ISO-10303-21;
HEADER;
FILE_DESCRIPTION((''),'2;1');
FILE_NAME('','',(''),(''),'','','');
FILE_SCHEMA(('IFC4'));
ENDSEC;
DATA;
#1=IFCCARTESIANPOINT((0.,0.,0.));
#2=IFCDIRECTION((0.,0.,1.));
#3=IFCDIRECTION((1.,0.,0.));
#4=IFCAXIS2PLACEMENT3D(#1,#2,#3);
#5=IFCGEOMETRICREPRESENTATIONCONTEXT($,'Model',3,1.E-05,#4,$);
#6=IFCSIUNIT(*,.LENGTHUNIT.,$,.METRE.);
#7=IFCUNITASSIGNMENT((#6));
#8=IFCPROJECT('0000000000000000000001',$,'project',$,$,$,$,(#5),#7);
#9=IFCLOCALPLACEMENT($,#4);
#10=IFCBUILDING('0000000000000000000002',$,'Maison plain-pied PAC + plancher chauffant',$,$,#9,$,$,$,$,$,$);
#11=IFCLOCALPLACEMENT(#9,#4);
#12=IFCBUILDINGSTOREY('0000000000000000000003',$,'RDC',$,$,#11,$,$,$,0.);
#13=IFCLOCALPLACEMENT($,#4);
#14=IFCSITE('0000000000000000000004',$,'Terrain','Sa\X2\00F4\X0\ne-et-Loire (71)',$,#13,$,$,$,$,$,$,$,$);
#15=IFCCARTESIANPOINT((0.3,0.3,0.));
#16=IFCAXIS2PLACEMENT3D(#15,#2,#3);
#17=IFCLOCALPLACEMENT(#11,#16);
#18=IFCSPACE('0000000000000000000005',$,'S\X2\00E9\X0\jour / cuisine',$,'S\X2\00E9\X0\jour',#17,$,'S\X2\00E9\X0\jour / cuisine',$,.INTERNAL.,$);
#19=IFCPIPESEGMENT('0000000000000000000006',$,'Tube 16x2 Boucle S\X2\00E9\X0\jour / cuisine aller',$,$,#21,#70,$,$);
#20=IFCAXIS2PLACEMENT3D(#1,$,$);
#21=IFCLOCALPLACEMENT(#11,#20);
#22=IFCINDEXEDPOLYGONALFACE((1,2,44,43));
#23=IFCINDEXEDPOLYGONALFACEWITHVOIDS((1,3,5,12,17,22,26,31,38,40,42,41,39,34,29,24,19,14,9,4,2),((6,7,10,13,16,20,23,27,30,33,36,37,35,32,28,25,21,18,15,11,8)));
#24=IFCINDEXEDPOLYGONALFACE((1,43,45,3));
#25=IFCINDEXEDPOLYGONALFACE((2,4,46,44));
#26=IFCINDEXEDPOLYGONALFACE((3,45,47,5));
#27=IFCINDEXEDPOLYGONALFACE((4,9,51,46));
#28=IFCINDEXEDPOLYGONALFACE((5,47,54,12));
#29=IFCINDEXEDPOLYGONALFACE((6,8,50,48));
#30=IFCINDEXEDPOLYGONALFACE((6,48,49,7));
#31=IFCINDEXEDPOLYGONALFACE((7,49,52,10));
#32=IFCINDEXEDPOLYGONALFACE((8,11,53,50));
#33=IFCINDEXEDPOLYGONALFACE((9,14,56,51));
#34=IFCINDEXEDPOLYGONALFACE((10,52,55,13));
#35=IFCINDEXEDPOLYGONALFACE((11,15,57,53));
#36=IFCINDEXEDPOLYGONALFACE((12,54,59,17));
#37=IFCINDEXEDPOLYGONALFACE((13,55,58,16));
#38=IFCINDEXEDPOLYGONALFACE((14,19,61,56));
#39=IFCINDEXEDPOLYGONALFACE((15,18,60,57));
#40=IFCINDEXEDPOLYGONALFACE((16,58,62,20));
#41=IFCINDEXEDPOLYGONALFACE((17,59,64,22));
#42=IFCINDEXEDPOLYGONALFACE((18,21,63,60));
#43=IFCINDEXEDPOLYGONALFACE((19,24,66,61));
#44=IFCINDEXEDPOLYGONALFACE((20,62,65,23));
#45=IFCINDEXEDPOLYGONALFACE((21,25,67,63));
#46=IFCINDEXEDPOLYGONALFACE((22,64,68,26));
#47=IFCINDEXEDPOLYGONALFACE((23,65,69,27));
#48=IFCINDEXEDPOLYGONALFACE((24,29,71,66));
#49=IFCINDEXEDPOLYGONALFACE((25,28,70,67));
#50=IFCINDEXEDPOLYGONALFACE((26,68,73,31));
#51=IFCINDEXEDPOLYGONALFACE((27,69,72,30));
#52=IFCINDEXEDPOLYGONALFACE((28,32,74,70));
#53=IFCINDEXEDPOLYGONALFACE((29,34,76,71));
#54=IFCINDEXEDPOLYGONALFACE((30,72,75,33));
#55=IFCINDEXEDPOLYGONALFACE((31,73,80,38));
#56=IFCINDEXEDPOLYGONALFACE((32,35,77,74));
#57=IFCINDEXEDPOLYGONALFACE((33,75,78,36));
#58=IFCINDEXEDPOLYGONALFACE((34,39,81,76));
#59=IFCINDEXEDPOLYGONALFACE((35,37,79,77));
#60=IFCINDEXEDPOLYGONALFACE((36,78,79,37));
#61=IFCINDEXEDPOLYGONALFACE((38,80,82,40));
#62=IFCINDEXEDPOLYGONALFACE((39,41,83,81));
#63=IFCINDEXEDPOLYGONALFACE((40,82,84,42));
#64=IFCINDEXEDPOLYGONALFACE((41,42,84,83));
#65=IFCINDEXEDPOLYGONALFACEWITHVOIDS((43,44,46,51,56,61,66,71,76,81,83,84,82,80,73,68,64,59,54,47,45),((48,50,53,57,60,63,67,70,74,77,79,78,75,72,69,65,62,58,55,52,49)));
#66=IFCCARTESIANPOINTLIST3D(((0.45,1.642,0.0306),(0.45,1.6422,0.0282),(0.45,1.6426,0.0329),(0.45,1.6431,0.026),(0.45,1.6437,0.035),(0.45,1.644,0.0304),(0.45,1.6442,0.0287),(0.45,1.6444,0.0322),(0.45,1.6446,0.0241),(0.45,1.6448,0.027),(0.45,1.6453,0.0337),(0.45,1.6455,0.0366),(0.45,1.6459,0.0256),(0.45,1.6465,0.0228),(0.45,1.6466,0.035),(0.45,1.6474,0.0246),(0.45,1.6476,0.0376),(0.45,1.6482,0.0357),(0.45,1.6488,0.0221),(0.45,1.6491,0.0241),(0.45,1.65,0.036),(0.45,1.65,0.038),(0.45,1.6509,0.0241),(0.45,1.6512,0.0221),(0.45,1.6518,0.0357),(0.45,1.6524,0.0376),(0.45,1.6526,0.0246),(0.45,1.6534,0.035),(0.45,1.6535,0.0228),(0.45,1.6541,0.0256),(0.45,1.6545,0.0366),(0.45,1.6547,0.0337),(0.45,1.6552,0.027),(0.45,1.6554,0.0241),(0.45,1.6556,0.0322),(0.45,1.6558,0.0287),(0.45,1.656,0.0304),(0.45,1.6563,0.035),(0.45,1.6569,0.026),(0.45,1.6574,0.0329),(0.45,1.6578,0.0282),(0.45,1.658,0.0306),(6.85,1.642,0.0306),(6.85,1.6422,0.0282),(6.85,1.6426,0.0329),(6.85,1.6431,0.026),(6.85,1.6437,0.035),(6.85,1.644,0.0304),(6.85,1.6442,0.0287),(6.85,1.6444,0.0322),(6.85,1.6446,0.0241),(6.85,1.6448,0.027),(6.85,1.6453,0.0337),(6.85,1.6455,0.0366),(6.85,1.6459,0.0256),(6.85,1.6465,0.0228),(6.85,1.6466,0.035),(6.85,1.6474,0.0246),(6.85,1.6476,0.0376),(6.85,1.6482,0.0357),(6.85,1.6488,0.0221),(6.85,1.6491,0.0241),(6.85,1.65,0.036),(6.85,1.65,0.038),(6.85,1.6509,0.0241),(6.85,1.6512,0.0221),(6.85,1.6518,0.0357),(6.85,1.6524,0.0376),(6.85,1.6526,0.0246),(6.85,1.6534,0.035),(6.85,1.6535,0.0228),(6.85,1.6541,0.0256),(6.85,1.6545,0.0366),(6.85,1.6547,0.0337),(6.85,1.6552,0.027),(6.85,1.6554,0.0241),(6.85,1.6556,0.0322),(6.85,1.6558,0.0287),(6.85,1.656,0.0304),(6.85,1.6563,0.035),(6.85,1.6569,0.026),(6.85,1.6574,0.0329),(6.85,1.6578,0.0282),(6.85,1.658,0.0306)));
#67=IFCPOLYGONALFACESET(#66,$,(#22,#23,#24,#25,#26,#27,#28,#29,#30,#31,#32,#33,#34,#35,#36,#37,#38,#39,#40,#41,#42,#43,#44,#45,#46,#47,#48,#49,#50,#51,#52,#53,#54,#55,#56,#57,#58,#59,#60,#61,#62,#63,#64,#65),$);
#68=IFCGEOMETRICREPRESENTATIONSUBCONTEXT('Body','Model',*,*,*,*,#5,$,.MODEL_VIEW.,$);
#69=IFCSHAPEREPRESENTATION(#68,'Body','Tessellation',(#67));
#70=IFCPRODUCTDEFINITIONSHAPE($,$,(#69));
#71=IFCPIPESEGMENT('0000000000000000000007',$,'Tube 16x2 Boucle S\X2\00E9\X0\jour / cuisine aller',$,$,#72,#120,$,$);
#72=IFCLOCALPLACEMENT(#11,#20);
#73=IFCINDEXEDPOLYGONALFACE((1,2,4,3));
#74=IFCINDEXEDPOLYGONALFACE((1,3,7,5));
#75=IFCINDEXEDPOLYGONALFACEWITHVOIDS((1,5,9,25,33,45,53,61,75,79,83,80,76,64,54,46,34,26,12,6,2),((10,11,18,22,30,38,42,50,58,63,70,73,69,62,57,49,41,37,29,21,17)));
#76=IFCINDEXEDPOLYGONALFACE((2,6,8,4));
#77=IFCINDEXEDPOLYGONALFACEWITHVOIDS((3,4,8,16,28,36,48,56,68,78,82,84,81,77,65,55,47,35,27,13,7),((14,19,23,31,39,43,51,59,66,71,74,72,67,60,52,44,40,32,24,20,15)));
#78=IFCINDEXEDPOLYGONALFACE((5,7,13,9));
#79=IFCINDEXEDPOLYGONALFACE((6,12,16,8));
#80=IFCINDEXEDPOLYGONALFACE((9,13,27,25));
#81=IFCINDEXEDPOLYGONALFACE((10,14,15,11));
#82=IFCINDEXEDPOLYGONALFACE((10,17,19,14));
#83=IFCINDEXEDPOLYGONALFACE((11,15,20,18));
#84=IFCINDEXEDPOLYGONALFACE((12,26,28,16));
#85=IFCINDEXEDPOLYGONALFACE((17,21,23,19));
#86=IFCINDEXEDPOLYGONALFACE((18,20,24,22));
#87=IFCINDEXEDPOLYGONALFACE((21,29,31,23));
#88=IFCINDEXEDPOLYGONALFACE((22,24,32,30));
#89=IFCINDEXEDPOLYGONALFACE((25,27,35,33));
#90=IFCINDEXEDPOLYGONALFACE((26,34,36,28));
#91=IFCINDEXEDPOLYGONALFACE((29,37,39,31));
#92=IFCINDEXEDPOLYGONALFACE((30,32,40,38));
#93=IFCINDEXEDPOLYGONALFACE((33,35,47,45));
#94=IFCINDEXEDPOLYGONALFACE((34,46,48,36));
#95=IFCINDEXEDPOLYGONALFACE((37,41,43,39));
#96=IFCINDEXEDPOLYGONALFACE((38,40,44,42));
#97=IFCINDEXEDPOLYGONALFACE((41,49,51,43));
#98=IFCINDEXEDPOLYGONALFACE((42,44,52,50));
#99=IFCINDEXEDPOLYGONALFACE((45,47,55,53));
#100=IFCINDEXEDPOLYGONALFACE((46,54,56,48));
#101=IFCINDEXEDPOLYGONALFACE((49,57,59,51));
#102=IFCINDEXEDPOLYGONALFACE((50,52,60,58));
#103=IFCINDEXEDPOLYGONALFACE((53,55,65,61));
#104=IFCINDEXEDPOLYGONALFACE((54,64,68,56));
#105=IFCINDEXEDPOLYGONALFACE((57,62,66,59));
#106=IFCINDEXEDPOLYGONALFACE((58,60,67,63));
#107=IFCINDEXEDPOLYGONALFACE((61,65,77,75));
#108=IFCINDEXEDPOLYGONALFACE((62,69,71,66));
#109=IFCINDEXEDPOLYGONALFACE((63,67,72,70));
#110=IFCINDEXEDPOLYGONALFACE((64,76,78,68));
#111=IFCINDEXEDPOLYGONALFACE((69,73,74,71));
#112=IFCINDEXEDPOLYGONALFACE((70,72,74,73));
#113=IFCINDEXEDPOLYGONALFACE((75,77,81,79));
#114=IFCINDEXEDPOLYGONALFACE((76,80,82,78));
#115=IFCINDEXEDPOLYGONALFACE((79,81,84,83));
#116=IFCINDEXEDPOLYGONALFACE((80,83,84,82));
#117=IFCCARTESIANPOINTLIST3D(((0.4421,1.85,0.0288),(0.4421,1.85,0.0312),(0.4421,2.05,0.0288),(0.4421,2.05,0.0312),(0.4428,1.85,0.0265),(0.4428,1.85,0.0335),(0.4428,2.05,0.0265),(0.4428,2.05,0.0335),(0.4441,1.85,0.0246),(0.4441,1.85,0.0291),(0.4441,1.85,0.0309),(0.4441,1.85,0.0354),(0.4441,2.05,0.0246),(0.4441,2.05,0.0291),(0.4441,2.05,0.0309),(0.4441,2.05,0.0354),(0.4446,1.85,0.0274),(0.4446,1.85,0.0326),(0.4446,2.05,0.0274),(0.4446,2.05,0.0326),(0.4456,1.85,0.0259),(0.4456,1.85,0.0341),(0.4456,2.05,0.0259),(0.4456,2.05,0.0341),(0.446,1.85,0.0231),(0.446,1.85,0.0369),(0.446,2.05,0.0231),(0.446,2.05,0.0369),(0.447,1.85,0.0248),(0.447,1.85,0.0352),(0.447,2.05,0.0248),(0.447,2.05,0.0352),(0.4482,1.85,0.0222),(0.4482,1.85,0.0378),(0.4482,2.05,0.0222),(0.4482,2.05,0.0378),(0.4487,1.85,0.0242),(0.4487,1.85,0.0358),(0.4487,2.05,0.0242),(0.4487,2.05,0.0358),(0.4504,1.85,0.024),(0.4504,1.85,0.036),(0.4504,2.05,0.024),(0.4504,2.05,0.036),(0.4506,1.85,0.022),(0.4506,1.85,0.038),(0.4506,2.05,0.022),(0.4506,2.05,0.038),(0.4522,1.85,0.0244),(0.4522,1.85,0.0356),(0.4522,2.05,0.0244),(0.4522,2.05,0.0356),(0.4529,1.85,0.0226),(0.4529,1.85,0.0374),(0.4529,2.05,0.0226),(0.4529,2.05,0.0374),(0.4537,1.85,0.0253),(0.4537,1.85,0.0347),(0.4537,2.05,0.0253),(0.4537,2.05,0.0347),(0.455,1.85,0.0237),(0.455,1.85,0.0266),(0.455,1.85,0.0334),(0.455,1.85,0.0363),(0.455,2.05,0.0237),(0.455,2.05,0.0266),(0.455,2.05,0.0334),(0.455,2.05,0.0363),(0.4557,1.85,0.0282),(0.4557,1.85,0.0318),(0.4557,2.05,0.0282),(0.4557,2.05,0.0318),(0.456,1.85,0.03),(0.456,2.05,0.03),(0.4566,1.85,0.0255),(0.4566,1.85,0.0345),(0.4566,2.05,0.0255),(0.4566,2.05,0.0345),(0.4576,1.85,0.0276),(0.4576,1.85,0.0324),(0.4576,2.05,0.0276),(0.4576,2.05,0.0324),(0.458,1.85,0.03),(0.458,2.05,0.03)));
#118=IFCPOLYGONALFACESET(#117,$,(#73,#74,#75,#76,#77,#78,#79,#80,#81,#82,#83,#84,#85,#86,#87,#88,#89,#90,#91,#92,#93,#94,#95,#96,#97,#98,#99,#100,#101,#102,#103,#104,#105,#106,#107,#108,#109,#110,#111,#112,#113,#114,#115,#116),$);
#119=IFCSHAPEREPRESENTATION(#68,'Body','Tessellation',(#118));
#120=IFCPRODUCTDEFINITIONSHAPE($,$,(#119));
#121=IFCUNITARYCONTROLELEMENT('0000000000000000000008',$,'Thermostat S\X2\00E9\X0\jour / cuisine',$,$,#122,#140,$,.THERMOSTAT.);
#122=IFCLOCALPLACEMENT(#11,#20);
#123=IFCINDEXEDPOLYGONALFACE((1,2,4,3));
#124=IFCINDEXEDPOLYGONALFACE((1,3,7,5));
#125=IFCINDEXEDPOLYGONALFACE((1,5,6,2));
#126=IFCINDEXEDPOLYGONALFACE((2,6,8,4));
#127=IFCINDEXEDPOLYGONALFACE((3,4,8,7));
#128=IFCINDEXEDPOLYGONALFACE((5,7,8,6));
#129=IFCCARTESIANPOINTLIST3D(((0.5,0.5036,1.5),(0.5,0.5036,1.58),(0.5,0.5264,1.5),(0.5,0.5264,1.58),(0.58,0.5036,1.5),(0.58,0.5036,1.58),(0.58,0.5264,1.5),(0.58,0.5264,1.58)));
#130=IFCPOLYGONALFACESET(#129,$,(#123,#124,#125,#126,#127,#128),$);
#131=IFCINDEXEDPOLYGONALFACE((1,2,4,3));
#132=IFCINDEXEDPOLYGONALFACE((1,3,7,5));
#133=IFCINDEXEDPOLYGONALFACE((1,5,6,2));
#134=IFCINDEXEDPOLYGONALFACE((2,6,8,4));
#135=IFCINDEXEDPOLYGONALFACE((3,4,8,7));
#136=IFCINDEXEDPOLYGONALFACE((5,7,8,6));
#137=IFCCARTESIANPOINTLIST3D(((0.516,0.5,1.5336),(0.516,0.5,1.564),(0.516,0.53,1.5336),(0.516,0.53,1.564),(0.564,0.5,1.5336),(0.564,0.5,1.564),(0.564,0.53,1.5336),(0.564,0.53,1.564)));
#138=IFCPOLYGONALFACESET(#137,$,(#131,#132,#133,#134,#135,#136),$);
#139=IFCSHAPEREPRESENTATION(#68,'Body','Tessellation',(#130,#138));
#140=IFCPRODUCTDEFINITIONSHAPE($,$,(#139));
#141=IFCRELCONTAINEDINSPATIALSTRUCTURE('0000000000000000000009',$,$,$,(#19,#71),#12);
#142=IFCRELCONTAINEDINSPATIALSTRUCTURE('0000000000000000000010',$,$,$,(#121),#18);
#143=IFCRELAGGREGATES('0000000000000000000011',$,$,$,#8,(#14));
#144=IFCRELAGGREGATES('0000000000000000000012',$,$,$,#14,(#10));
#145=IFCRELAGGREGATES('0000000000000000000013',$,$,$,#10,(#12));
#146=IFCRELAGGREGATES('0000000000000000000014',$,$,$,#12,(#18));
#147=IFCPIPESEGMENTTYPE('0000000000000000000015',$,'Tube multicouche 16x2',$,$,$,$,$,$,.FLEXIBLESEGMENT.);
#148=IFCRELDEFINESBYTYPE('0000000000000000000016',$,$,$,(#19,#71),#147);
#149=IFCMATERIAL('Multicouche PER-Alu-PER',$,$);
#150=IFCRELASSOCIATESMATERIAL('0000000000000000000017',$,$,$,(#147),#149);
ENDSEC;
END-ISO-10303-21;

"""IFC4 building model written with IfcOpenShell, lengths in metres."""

from ifc_helpers import new_model, si_unit, frame, frame_2d, origin_with_axes, place, context, subcontext, project, spatial, rectangle, hollow_circle, extrude, material, type_object, element, save


model = new_model("IFC4")

# Units and contexts
model_context = context("Model", 3, precision=1e-05, world=origin_with_axes())
body_context = subcontext(model_context, "Body", "Model", "MODEL_VIEW")
ifc_project = project(units=[si_unit("LENGTHUNIT", "METRE")], contexts=[model_context])

# Site, building, storey
site_placement = place(None, origin_with_axes())
site = spatial("IfcSite", under=ifc_project, at=site_placement, Name="Terrain", Description="Saône-et-Loire (71)")
building_placement = place(None, origin_with_axes())
building = spatial("IfcBuilding", under=site, at=building_placement, Name="Maison plain-pied PAC + plancher chauffant")
storey_placement = place(building_placement, origin_with_axes())
storey = spatial("IfcBuildingStorey", under=building, at=storey_placement, Name="RDC", Elevation=0.0)

# Pipe segments
ifc_material_1 = material(Name="Multicouche PER-Alu-PER")
pipe_segment_type = type_object("IfcPipeSegmentType", Name="Tube multicouche 16x2", PredefinedType="FLEXIBLESEGMENT", material=ifc_material_1)
pipe_segment_1_placement = place(storey_placement, frame((0.45, 1.65, 0.03), z_axis=(1.0, 0.0, 0.0), x_axis=(0.0, 0.0, 1.0)))
element("IfcPipeSegment", 1, at=pipe_segment_1_placement, inside=storey, type_object=pipe_segment_type, Name="Tube 16x2 Boucle Séjour / cuisine aller", context=body_context, shape_type="SweptSolid", body=[
    extrude(hollow_circle(Radius=0.008, WallThickness=0.002), origin_with_axes(), (0.0, 0.0, 1.0), 6.4),
])
pipe_segment_2_placement = place(storey_placement, frame((0.45, 1.85, 0.03), z_axis=(0.0, 1.0, 0.0), x_axis=(1.0, 0.0, 0.0)))
element("IfcPipeSegment", 2, at=pipe_segment_2_placement, inside=storey, type_object=pipe_segment_type, Name="Tube 16x2 Boucle Séjour / cuisine aller", context=body_context, shape_type="SweptSolid", body=[
    extrude(hollow_circle(Radius=0.008, WallThickness=0.002), origin_with_axes(), (0.0, 0.0, 1.0), 0.2),
])

# Shared definitions
space_placement = place(storey_placement, frame((0.3, 0.3, 0.0), z_axis=(0.0, 0.0, 1.0), x_axis=(1.0, 0.0, 0.0)))
space = spatial("IfcSpace", under=storey, at=space_placement, Name="Séjour / cuisine", ObjectType="Séjour", LongName="Séjour / cuisine", PredefinedType="INTERNAL")

# Unitary control element
unitary_control_element_placement = place(space_placement, frame((0.2, 0.2, 1.5), z_axis=(0.0, 0.0, 1.0), x_axis=(1.0, 0.0, 0.0)))
element("IfcUnitaryControlElement", 3, at=unitary_control_element_placement, inside=space, Name="Thermostat Séjour / cuisine", PredefinedType="THERMOSTAT", context=body_context, shape_type="SweptSolid", body=[
    extrude(rectangle(XDim=0.08, YDim=0.0228, at=frame_2d((0.04, 0.0114))), frame((0.0, 0.0036, 0.0), z_axis=(0.0, 0.0, 1.0), x_axis=(1.0, 0.0, 0.0)), (0.0, 0.0, 1.0), 0.08),
    extrude(rectangle(XDim=0.048, YDim=0.03, at=frame_2d((0.024, 0.015))), frame((0.016, 0.0, 0.0336), z_axis=(0.0, 0.0, 1.0), x_axis=(1.0, 0.0, 0.0)), (0.0, 0.0, 1.0), 0.0304),
])

save(model, "model.ifc")
